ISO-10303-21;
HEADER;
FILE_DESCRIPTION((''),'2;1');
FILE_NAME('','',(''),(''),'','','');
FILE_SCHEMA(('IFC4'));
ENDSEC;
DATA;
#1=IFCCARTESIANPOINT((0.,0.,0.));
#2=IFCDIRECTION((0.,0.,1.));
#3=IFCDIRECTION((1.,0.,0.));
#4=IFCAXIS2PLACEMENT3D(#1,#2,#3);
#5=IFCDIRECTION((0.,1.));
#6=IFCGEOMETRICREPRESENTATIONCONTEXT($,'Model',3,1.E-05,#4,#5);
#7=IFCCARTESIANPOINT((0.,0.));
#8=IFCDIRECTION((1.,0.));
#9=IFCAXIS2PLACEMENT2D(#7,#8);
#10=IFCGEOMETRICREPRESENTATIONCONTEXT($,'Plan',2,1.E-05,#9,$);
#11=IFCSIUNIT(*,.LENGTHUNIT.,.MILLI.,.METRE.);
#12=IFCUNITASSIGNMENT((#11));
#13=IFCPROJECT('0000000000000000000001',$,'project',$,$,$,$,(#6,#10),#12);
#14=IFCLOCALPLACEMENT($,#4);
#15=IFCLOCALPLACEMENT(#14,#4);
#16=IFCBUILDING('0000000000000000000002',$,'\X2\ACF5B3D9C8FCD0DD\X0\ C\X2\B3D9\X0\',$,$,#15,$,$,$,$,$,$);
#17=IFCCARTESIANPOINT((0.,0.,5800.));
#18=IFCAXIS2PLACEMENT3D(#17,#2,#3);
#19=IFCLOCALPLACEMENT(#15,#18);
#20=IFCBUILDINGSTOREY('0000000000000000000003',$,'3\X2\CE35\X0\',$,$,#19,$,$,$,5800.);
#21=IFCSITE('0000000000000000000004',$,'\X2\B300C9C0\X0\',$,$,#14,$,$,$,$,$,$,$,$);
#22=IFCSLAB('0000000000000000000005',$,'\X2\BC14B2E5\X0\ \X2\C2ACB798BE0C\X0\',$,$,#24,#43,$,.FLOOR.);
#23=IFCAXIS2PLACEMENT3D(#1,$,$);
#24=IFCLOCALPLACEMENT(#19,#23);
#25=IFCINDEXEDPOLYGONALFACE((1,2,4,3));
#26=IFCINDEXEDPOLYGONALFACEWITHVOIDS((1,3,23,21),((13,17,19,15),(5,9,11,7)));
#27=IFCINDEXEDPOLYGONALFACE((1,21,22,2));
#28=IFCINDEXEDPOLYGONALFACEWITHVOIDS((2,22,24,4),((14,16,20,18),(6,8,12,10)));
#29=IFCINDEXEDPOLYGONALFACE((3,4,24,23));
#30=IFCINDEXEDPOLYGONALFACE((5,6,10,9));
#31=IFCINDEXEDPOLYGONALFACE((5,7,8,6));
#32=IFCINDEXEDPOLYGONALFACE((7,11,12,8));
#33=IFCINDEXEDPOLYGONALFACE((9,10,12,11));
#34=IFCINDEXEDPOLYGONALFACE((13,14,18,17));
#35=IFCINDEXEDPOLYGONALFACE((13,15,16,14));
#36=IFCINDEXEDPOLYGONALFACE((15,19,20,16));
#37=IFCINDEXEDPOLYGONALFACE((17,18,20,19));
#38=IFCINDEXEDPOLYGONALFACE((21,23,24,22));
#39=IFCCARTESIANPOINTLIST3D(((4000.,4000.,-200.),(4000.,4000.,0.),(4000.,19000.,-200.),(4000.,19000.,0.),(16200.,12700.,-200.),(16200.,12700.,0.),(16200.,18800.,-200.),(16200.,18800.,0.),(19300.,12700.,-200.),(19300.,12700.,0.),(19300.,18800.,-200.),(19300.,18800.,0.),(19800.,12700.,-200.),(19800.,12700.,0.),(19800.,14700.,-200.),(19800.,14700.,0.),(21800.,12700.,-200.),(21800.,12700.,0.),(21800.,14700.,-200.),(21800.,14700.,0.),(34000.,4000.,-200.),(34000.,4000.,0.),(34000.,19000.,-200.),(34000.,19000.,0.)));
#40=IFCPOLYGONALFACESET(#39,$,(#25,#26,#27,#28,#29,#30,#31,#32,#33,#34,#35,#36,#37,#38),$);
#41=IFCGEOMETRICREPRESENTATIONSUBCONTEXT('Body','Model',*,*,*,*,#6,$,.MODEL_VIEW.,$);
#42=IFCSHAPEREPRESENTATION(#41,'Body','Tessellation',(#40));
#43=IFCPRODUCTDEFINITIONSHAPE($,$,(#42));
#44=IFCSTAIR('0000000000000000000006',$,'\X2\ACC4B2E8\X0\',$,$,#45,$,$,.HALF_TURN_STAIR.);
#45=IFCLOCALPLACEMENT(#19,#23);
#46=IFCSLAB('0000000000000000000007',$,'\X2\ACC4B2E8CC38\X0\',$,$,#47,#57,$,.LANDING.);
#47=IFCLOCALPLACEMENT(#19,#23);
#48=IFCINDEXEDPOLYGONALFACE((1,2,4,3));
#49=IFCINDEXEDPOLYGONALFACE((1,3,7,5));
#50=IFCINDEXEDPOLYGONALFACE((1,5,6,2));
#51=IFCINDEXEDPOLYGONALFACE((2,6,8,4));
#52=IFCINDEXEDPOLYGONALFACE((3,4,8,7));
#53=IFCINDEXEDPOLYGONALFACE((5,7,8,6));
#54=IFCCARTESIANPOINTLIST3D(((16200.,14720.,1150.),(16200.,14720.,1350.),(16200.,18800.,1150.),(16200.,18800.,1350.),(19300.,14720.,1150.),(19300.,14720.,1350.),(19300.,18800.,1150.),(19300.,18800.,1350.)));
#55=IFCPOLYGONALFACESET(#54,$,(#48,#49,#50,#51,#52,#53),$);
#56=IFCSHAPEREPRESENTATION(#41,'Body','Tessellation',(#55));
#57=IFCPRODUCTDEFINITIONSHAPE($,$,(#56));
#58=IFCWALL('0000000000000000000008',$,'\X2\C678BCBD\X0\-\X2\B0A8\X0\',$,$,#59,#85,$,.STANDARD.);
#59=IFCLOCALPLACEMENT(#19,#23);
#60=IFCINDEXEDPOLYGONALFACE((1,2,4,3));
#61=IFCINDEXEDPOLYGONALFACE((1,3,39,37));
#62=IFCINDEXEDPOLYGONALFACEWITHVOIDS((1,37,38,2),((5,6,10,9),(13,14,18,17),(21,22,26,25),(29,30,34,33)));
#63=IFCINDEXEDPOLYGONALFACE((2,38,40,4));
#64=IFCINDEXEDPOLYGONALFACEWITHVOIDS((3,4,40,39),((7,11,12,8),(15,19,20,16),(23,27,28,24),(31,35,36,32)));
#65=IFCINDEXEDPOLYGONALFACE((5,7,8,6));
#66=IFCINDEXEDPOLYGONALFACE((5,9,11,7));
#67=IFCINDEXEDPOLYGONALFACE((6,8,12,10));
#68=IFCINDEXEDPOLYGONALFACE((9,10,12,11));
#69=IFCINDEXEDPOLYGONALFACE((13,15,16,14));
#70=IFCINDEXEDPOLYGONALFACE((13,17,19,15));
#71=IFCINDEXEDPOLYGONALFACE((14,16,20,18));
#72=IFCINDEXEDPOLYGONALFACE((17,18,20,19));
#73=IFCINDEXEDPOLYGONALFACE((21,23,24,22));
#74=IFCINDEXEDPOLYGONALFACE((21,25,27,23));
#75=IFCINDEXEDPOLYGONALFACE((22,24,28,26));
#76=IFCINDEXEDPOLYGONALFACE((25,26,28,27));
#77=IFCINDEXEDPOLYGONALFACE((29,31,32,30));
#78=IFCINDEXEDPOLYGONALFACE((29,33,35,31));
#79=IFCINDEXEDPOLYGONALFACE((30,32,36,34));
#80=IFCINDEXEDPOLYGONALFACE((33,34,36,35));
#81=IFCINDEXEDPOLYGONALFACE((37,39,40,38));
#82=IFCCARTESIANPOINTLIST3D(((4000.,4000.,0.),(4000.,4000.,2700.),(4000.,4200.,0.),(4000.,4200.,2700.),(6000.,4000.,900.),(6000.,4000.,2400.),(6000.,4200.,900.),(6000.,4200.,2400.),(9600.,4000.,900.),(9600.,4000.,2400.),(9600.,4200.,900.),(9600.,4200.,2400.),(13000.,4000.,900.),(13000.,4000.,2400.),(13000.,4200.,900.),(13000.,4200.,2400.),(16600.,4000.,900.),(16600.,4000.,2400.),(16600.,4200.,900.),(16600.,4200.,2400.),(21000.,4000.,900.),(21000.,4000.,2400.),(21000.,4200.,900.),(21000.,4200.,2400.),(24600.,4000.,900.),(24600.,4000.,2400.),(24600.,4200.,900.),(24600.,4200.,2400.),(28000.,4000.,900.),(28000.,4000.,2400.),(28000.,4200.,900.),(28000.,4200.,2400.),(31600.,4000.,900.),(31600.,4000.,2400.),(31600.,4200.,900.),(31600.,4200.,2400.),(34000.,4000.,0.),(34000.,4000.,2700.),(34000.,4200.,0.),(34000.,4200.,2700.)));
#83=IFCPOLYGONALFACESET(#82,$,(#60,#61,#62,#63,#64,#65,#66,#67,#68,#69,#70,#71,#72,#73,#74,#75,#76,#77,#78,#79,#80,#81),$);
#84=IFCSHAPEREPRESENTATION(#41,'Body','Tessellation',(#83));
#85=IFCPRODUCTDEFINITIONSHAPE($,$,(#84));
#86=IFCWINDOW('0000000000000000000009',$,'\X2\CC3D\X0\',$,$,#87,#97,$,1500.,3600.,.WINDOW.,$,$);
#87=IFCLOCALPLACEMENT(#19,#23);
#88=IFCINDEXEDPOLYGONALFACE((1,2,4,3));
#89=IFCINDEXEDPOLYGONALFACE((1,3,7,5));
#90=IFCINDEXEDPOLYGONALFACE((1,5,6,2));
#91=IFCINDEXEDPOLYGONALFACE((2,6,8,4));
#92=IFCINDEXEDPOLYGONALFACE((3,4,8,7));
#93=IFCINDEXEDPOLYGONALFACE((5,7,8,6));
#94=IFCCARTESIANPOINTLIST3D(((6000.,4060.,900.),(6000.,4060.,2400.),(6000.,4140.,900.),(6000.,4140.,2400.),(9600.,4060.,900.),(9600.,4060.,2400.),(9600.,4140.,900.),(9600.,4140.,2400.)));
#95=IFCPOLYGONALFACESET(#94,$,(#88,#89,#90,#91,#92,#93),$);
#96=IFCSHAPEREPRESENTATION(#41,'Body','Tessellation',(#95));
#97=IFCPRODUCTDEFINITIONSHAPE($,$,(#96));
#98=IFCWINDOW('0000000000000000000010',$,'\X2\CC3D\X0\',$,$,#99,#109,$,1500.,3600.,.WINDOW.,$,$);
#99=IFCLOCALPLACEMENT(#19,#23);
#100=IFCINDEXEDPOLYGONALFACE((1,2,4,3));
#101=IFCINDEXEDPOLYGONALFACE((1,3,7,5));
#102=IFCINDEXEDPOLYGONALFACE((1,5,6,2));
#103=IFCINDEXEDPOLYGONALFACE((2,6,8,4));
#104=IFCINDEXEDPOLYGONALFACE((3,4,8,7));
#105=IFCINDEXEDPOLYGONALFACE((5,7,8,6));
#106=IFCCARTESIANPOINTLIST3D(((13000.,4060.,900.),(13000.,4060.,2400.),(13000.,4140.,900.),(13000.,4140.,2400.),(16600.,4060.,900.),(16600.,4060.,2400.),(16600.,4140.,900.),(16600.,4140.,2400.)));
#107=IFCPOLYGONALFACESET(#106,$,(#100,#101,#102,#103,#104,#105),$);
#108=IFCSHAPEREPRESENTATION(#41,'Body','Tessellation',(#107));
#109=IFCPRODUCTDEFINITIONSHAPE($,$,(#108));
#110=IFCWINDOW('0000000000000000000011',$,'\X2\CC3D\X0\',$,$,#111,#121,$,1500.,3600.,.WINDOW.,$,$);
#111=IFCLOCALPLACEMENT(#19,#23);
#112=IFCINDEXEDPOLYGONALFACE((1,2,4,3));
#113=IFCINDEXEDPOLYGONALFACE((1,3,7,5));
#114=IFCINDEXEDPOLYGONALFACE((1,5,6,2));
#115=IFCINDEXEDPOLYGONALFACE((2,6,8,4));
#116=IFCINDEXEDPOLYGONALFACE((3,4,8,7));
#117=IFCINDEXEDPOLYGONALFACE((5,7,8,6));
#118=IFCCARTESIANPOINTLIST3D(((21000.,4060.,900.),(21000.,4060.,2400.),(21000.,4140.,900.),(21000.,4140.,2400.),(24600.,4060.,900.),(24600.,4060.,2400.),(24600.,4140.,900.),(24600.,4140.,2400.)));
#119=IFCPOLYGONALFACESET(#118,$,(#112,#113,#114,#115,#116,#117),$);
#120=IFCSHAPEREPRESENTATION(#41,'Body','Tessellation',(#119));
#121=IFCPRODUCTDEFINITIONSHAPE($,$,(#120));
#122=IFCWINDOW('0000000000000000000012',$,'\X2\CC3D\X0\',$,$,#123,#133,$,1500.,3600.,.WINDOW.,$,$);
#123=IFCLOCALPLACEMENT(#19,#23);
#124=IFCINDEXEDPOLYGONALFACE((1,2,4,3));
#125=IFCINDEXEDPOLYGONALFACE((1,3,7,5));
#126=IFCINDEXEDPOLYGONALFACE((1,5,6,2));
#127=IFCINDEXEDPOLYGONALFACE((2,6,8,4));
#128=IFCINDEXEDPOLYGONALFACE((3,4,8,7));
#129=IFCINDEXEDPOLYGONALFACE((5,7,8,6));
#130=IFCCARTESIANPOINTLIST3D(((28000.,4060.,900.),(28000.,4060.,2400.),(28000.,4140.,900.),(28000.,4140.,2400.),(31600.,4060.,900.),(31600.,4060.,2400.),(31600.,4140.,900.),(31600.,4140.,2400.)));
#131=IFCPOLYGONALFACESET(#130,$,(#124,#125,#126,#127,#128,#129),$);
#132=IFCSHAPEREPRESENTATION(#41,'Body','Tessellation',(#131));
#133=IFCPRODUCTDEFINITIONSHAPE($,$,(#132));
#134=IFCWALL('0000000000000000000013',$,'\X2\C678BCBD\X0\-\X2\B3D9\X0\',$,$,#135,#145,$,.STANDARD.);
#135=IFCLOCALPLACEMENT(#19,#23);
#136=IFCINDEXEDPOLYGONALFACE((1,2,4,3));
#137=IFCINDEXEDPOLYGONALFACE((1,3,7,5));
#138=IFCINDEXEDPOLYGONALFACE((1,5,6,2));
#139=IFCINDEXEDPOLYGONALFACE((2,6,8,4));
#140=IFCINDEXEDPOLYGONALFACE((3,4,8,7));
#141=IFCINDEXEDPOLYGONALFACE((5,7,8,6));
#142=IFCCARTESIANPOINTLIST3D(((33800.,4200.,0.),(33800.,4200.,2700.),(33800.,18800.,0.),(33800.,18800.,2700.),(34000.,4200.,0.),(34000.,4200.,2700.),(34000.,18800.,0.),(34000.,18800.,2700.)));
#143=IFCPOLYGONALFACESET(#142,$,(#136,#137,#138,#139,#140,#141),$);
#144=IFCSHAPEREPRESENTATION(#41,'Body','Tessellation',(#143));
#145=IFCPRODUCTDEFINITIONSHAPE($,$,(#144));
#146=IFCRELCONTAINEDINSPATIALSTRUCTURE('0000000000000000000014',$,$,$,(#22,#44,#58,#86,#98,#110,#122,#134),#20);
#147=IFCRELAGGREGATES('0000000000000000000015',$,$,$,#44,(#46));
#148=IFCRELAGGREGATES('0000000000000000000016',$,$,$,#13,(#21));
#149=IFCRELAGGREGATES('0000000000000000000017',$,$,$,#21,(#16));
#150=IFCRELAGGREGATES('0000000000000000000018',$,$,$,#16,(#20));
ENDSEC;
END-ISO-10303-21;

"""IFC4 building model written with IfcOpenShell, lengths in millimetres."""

from ifc_helpers import new_model, si_unit, direction, frame, origin_with_axes, origin_2d_with_axis, place, context, subcontext, project, spatial, polyline, outline, extrude, element, fill, aggregate, save


model = new_model("IFC4")

# Units and contexts
model_context = context("Model", 3, precision=1e-05, world=origin_with_axes(), true_north=direction((0.0, 1.0)))
plan_context = context("Plan", 2, precision=1e-05, world=origin_2d_with_axis())
body_context = subcontext(model_context, "Body", "Model", "MODEL_VIEW")
ifc_project = project(units=[si_unit("LENGTHUNIT", "METRE", prefix="MILLI")], contexts=[model_context, plan_context])

# Site, building, storey
site_placement = place(None, origin_with_axes())
site = spatial("IfcSite", under=ifc_project, at=site_placement, Name="대지")
building_placement = place(site_placement, origin_with_axes())
building = spatial("IfcBuilding", under=site, at=building_placement, Name="공동주택 C동")
storey_placement = place(building_placement, frame((0.0, 0.0, 5800.0), z_axis=(0.0, 0.0, 1.0), x_axis=(1.0, 0.0, 0.0)))
storey = spatial("IfcBuildingStorey", under=building, at=storey_placement, Name="3층", Elevation=5800.0)

# Slab
slab_1_placement = place(storey_placement, origin_with_axes())
element("IfcSlab", 1, at=slab_1_placement, inside=storey, Name="바닥 슬래브", PredefinedType="FLOOR", context=body_context, shape_type="SweptSolid", body=[
    extrude(outline(polyline([(4000.0, 4000.0), (34000.0, 4000.0), (34000.0, 19000.0), (4000.0, 19000.0), (4000.0, 4000.0)]), holes=[polyline([(16200.0, 12700.0), (19300.0, 12700.0), (19300.0, 18800.0), (16200.0, 18800.0), (16200.0, 12700.0)]), polyline([(19800.0, 12700.0), (21800.0, 12700.0), (21800.0, 14700.0), (19800.0, 14700.0), (19800.0, 12700.0)])]), frame((0.0, 0.0, -200.0), z_axis=(0.0, 0.0, 1.0), x_axis=(1.0, 0.0, 0.0)), (0.0, 0.0, 1.0), 200.0),
])

# Stair, slab
stair_placement = place(storey_placement, origin_with_axes())
stair = element("IfcStair", 2, at=stair_placement, inside=storey, Name="계단", PredefinedType="HALF_TURN_STAIR")
slab_2_placement = place(stair_placement, origin_with_axes())
slab_2 = element("IfcSlab", 3, at=slab_2_placement, Name="계단참", PredefinedType="LANDING", context=body_context, shape_type="SweptSolid", body=[
    extrude(outline(polyline([(16200.0, 14720.0), (19300.0, 14720.0), (19300.0, 18800.0), (16200.0, 18800.0), (16200.0, 14720.0)])), frame((0.0, 0.0, 1150.0), z_axis=(0.0, 0.0, 1.0), x_axis=(1.0, 0.0, 0.0)), (0.0, 0.0, 1.0), 200.0),
])

# Wall, openings, windows
wall_1_placement = place(storey_placement, origin_with_axes())
wall_1 = element("IfcWall", 4, at=wall_1_placement, inside=storey, Name="외벽-남", PredefinedType="STANDARD", context=body_context, shape_type="SweptSolid", body=[
    extrude(outline(polyline([(4000.0, 4200.0), (34000.0, 4200.0), (34000.0, 4000.0), (4000.0, 4000.0), (4000.0, 4200.0)])), origin_with_axes(), (0.0, 0.0, 1.0), 2700.0),
])
opening_1_placement = place(storey_placement, origin_with_axes())
opening_1 = element("IfcOpeningElement", 5, at=opening_1_placement, cuts=wall_1, PredefinedType="OPENING", context=body_context, shape_type="SweptSolid", body=[
    extrude(outline(polyline([(6000.0, 3950.0), (9600.0, 3950.0), (9600.0, 4250.0), (6000.0, 4250.0), (6000.0, 3950.0)])), frame((0.0, 0.0, 900.0), z_axis=(0.0, 0.0, 1.0), x_axis=(1.0, 0.0, 0.0)), (0.0, 0.0, 1.0), 1500.0),
])
opening_2_placement = place(storey_placement, origin_with_axes())
opening_2 = element("IfcOpeningElement", 6, at=opening_2_placement, cuts=wall_1, PredefinedType="OPENING", context=body_context, shape_type="SweptSolid", body=[
    extrude(outline(polyline([(13000.0, 3950.0), (16600.0, 3950.0), (16600.0, 4250.0), (13000.0, 4250.0), (13000.0, 3950.0)])), frame((0.0, 0.0, 900.0), z_axis=(0.0, 0.0, 1.0), x_axis=(1.0, 0.0, 0.0)), (0.0, 0.0, 1.0), 1500.0),
])
opening_3_placement = place(storey_placement, origin_with_axes())
opening_3 = element("IfcOpeningElement", 7, at=opening_3_placement, cuts=wall_1, PredefinedType="OPENING", context=body_context, shape_type="SweptSolid", body=[
    extrude(outline(polyline([(21000.0, 3950.0), (24600.0, 3950.0), (24600.0, 4250.0), (21000.0, 4250.0), (21000.0, 3950.0)])), frame((0.0, 0.0, 900.0), z_axis=(0.0, 0.0, 1.0), x_axis=(1.0, 0.0, 0.0)), (0.0, 0.0, 1.0), 1500.0),
])
opening_4_placement = place(storey_placement, origin_with_axes())
opening_4 = element("IfcOpeningElement", 8, at=opening_4_placement, cuts=wall_1, PredefinedType="OPENING", context=body_context, shape_type="SweptSolid", body=[
    extrude(outline(polyline([(28000.0, 3950.0), (31600.0, 3950.0), (31600.0, 4250.0), (28000.0, 4250.0), (28000.0, 3950.0)])), frame((0.0, 0.0, 900.0), z_axis=(0.0, 0.0, 1.0), x_axis=(1.0, 0.0, 0.0)), (0.0, 0.0, 1.0), 1500.0),
])
window_1_placement = place(storey_placement, origin_with_axes())
window_1 = element("IfcWindow", 9, at=window_1_placement, inside=storey, Name="창", OverallHeight=1500.0, OverallWidth=3600.0, PredefinedType="WINDOW", context=body_context, shape_type="SweptSolid", body=[
    extrude(outline(polyline([(6000.0, 4060.0), (9600.0, 4060.0), (9600.0, 4140.0), (6000.0, 4140.0), (6000.0, 4060.0)])), frame((0.0, 0.0, 900.0), z_axis=(0.0, 0.0, 1.0), x_axis=(1.0, 0.0, 0.0)), (0.0, 0.0, 1.0), 1500.0),
])
fill(opening_1, window_1)
window_2_placement = place(storey_placement, origin_with_axes())
window_2 = element("IfcWindow", 10, at=window_2_placement, inside=storey, Name="창", OverallHeight=1500.0, OverallWidth=3600.0, PredefinedType="WINDOW", context=body_context, shape_type="SweptSolid", body=[
    extrude(outline(polyline([(13000.0, 4060.0), (16600.0, 4060.0), (16600.0, 4140.0), (13000.0, 4140.0), (13000.0, 4060.0)])), frame((0.0, 0.0, 900.0), z_axis=(0.0, 0.0, 1.0), x_axis=(1.0, 0.0, 0.0)), (0.0, 0.0, 1.0), 1500.0),
])
fill(opening_2, window_2)
window_3_placement = place(storey_placement, origin_with_axes())
window_3 = element("IfcWindow", 11, at=window_3_placement, inside=storey, Name="창", OverallHeight=1500.0, OverallWidth=3600.0, PredefinedType="WINDOW", context=body_context, shape_type="SweptSolid", body=[
    extrude(outline(polyline([(21000.0, 4060.0), (24600.0, 4060.0), (24600.0, 4140.0), (21000.0, 4140.0), (21000.0, 4060.0)])), frame((0.0, 0.0, 900.0), z_axis=(0.0, 0.0, 1.0), x_axis=(1.0, 0.0, 0.0)), (0.0, 0.0, 1.0), 1500.0),
])
fill(opening_3, window_3)
window_4_placement = place(storey_placement, origin_with_axes())
window_4 = element("IfcWindow", 12, at=window_4_placement, inside=storey, Name="창", OverallHeight=1500.0, OverallWidth=3600.0, PredefinedType="WINDOW", context=body_context, shape_type="SweptSolid", body=[
    extrude(outline(polyline([(28000.0, 4060.0), (31600.0, 4060.0), (31600.0, 4140.0), (28000.0, 4140.0), (28000.0, 4060.0)])), frame((0.0, 0.0, 900.0), z_axis=(0.0, 0.0, 1.0), x_axis=(1.0, 0.0, 0.0)), (0.0, 0.0, 1.0), 1500.0),
])
fill(opening_4, window_4)

# Wall
wall_2_placement = place(storey_placement, origin_with_axes())
element("IfcWall", 13, at=wall_2_placement, inside=storey, Name="외벽-동", PredefinedType="STANDARD", context=body_context, shape_type="SweptSolid", body=[
    extrude(outline(polyline([(33800.0, 4200.0), (33800.0, 18800.0), (34000.0, 18800.0), (34000.0, 4200.0), (33800.0, 4200.0)])), origin_with_axes(), (0.0, 0.0, 1.0), 2700.0),
])

aggregate(stair, [slab_2])

save(model, "model.ifc")
